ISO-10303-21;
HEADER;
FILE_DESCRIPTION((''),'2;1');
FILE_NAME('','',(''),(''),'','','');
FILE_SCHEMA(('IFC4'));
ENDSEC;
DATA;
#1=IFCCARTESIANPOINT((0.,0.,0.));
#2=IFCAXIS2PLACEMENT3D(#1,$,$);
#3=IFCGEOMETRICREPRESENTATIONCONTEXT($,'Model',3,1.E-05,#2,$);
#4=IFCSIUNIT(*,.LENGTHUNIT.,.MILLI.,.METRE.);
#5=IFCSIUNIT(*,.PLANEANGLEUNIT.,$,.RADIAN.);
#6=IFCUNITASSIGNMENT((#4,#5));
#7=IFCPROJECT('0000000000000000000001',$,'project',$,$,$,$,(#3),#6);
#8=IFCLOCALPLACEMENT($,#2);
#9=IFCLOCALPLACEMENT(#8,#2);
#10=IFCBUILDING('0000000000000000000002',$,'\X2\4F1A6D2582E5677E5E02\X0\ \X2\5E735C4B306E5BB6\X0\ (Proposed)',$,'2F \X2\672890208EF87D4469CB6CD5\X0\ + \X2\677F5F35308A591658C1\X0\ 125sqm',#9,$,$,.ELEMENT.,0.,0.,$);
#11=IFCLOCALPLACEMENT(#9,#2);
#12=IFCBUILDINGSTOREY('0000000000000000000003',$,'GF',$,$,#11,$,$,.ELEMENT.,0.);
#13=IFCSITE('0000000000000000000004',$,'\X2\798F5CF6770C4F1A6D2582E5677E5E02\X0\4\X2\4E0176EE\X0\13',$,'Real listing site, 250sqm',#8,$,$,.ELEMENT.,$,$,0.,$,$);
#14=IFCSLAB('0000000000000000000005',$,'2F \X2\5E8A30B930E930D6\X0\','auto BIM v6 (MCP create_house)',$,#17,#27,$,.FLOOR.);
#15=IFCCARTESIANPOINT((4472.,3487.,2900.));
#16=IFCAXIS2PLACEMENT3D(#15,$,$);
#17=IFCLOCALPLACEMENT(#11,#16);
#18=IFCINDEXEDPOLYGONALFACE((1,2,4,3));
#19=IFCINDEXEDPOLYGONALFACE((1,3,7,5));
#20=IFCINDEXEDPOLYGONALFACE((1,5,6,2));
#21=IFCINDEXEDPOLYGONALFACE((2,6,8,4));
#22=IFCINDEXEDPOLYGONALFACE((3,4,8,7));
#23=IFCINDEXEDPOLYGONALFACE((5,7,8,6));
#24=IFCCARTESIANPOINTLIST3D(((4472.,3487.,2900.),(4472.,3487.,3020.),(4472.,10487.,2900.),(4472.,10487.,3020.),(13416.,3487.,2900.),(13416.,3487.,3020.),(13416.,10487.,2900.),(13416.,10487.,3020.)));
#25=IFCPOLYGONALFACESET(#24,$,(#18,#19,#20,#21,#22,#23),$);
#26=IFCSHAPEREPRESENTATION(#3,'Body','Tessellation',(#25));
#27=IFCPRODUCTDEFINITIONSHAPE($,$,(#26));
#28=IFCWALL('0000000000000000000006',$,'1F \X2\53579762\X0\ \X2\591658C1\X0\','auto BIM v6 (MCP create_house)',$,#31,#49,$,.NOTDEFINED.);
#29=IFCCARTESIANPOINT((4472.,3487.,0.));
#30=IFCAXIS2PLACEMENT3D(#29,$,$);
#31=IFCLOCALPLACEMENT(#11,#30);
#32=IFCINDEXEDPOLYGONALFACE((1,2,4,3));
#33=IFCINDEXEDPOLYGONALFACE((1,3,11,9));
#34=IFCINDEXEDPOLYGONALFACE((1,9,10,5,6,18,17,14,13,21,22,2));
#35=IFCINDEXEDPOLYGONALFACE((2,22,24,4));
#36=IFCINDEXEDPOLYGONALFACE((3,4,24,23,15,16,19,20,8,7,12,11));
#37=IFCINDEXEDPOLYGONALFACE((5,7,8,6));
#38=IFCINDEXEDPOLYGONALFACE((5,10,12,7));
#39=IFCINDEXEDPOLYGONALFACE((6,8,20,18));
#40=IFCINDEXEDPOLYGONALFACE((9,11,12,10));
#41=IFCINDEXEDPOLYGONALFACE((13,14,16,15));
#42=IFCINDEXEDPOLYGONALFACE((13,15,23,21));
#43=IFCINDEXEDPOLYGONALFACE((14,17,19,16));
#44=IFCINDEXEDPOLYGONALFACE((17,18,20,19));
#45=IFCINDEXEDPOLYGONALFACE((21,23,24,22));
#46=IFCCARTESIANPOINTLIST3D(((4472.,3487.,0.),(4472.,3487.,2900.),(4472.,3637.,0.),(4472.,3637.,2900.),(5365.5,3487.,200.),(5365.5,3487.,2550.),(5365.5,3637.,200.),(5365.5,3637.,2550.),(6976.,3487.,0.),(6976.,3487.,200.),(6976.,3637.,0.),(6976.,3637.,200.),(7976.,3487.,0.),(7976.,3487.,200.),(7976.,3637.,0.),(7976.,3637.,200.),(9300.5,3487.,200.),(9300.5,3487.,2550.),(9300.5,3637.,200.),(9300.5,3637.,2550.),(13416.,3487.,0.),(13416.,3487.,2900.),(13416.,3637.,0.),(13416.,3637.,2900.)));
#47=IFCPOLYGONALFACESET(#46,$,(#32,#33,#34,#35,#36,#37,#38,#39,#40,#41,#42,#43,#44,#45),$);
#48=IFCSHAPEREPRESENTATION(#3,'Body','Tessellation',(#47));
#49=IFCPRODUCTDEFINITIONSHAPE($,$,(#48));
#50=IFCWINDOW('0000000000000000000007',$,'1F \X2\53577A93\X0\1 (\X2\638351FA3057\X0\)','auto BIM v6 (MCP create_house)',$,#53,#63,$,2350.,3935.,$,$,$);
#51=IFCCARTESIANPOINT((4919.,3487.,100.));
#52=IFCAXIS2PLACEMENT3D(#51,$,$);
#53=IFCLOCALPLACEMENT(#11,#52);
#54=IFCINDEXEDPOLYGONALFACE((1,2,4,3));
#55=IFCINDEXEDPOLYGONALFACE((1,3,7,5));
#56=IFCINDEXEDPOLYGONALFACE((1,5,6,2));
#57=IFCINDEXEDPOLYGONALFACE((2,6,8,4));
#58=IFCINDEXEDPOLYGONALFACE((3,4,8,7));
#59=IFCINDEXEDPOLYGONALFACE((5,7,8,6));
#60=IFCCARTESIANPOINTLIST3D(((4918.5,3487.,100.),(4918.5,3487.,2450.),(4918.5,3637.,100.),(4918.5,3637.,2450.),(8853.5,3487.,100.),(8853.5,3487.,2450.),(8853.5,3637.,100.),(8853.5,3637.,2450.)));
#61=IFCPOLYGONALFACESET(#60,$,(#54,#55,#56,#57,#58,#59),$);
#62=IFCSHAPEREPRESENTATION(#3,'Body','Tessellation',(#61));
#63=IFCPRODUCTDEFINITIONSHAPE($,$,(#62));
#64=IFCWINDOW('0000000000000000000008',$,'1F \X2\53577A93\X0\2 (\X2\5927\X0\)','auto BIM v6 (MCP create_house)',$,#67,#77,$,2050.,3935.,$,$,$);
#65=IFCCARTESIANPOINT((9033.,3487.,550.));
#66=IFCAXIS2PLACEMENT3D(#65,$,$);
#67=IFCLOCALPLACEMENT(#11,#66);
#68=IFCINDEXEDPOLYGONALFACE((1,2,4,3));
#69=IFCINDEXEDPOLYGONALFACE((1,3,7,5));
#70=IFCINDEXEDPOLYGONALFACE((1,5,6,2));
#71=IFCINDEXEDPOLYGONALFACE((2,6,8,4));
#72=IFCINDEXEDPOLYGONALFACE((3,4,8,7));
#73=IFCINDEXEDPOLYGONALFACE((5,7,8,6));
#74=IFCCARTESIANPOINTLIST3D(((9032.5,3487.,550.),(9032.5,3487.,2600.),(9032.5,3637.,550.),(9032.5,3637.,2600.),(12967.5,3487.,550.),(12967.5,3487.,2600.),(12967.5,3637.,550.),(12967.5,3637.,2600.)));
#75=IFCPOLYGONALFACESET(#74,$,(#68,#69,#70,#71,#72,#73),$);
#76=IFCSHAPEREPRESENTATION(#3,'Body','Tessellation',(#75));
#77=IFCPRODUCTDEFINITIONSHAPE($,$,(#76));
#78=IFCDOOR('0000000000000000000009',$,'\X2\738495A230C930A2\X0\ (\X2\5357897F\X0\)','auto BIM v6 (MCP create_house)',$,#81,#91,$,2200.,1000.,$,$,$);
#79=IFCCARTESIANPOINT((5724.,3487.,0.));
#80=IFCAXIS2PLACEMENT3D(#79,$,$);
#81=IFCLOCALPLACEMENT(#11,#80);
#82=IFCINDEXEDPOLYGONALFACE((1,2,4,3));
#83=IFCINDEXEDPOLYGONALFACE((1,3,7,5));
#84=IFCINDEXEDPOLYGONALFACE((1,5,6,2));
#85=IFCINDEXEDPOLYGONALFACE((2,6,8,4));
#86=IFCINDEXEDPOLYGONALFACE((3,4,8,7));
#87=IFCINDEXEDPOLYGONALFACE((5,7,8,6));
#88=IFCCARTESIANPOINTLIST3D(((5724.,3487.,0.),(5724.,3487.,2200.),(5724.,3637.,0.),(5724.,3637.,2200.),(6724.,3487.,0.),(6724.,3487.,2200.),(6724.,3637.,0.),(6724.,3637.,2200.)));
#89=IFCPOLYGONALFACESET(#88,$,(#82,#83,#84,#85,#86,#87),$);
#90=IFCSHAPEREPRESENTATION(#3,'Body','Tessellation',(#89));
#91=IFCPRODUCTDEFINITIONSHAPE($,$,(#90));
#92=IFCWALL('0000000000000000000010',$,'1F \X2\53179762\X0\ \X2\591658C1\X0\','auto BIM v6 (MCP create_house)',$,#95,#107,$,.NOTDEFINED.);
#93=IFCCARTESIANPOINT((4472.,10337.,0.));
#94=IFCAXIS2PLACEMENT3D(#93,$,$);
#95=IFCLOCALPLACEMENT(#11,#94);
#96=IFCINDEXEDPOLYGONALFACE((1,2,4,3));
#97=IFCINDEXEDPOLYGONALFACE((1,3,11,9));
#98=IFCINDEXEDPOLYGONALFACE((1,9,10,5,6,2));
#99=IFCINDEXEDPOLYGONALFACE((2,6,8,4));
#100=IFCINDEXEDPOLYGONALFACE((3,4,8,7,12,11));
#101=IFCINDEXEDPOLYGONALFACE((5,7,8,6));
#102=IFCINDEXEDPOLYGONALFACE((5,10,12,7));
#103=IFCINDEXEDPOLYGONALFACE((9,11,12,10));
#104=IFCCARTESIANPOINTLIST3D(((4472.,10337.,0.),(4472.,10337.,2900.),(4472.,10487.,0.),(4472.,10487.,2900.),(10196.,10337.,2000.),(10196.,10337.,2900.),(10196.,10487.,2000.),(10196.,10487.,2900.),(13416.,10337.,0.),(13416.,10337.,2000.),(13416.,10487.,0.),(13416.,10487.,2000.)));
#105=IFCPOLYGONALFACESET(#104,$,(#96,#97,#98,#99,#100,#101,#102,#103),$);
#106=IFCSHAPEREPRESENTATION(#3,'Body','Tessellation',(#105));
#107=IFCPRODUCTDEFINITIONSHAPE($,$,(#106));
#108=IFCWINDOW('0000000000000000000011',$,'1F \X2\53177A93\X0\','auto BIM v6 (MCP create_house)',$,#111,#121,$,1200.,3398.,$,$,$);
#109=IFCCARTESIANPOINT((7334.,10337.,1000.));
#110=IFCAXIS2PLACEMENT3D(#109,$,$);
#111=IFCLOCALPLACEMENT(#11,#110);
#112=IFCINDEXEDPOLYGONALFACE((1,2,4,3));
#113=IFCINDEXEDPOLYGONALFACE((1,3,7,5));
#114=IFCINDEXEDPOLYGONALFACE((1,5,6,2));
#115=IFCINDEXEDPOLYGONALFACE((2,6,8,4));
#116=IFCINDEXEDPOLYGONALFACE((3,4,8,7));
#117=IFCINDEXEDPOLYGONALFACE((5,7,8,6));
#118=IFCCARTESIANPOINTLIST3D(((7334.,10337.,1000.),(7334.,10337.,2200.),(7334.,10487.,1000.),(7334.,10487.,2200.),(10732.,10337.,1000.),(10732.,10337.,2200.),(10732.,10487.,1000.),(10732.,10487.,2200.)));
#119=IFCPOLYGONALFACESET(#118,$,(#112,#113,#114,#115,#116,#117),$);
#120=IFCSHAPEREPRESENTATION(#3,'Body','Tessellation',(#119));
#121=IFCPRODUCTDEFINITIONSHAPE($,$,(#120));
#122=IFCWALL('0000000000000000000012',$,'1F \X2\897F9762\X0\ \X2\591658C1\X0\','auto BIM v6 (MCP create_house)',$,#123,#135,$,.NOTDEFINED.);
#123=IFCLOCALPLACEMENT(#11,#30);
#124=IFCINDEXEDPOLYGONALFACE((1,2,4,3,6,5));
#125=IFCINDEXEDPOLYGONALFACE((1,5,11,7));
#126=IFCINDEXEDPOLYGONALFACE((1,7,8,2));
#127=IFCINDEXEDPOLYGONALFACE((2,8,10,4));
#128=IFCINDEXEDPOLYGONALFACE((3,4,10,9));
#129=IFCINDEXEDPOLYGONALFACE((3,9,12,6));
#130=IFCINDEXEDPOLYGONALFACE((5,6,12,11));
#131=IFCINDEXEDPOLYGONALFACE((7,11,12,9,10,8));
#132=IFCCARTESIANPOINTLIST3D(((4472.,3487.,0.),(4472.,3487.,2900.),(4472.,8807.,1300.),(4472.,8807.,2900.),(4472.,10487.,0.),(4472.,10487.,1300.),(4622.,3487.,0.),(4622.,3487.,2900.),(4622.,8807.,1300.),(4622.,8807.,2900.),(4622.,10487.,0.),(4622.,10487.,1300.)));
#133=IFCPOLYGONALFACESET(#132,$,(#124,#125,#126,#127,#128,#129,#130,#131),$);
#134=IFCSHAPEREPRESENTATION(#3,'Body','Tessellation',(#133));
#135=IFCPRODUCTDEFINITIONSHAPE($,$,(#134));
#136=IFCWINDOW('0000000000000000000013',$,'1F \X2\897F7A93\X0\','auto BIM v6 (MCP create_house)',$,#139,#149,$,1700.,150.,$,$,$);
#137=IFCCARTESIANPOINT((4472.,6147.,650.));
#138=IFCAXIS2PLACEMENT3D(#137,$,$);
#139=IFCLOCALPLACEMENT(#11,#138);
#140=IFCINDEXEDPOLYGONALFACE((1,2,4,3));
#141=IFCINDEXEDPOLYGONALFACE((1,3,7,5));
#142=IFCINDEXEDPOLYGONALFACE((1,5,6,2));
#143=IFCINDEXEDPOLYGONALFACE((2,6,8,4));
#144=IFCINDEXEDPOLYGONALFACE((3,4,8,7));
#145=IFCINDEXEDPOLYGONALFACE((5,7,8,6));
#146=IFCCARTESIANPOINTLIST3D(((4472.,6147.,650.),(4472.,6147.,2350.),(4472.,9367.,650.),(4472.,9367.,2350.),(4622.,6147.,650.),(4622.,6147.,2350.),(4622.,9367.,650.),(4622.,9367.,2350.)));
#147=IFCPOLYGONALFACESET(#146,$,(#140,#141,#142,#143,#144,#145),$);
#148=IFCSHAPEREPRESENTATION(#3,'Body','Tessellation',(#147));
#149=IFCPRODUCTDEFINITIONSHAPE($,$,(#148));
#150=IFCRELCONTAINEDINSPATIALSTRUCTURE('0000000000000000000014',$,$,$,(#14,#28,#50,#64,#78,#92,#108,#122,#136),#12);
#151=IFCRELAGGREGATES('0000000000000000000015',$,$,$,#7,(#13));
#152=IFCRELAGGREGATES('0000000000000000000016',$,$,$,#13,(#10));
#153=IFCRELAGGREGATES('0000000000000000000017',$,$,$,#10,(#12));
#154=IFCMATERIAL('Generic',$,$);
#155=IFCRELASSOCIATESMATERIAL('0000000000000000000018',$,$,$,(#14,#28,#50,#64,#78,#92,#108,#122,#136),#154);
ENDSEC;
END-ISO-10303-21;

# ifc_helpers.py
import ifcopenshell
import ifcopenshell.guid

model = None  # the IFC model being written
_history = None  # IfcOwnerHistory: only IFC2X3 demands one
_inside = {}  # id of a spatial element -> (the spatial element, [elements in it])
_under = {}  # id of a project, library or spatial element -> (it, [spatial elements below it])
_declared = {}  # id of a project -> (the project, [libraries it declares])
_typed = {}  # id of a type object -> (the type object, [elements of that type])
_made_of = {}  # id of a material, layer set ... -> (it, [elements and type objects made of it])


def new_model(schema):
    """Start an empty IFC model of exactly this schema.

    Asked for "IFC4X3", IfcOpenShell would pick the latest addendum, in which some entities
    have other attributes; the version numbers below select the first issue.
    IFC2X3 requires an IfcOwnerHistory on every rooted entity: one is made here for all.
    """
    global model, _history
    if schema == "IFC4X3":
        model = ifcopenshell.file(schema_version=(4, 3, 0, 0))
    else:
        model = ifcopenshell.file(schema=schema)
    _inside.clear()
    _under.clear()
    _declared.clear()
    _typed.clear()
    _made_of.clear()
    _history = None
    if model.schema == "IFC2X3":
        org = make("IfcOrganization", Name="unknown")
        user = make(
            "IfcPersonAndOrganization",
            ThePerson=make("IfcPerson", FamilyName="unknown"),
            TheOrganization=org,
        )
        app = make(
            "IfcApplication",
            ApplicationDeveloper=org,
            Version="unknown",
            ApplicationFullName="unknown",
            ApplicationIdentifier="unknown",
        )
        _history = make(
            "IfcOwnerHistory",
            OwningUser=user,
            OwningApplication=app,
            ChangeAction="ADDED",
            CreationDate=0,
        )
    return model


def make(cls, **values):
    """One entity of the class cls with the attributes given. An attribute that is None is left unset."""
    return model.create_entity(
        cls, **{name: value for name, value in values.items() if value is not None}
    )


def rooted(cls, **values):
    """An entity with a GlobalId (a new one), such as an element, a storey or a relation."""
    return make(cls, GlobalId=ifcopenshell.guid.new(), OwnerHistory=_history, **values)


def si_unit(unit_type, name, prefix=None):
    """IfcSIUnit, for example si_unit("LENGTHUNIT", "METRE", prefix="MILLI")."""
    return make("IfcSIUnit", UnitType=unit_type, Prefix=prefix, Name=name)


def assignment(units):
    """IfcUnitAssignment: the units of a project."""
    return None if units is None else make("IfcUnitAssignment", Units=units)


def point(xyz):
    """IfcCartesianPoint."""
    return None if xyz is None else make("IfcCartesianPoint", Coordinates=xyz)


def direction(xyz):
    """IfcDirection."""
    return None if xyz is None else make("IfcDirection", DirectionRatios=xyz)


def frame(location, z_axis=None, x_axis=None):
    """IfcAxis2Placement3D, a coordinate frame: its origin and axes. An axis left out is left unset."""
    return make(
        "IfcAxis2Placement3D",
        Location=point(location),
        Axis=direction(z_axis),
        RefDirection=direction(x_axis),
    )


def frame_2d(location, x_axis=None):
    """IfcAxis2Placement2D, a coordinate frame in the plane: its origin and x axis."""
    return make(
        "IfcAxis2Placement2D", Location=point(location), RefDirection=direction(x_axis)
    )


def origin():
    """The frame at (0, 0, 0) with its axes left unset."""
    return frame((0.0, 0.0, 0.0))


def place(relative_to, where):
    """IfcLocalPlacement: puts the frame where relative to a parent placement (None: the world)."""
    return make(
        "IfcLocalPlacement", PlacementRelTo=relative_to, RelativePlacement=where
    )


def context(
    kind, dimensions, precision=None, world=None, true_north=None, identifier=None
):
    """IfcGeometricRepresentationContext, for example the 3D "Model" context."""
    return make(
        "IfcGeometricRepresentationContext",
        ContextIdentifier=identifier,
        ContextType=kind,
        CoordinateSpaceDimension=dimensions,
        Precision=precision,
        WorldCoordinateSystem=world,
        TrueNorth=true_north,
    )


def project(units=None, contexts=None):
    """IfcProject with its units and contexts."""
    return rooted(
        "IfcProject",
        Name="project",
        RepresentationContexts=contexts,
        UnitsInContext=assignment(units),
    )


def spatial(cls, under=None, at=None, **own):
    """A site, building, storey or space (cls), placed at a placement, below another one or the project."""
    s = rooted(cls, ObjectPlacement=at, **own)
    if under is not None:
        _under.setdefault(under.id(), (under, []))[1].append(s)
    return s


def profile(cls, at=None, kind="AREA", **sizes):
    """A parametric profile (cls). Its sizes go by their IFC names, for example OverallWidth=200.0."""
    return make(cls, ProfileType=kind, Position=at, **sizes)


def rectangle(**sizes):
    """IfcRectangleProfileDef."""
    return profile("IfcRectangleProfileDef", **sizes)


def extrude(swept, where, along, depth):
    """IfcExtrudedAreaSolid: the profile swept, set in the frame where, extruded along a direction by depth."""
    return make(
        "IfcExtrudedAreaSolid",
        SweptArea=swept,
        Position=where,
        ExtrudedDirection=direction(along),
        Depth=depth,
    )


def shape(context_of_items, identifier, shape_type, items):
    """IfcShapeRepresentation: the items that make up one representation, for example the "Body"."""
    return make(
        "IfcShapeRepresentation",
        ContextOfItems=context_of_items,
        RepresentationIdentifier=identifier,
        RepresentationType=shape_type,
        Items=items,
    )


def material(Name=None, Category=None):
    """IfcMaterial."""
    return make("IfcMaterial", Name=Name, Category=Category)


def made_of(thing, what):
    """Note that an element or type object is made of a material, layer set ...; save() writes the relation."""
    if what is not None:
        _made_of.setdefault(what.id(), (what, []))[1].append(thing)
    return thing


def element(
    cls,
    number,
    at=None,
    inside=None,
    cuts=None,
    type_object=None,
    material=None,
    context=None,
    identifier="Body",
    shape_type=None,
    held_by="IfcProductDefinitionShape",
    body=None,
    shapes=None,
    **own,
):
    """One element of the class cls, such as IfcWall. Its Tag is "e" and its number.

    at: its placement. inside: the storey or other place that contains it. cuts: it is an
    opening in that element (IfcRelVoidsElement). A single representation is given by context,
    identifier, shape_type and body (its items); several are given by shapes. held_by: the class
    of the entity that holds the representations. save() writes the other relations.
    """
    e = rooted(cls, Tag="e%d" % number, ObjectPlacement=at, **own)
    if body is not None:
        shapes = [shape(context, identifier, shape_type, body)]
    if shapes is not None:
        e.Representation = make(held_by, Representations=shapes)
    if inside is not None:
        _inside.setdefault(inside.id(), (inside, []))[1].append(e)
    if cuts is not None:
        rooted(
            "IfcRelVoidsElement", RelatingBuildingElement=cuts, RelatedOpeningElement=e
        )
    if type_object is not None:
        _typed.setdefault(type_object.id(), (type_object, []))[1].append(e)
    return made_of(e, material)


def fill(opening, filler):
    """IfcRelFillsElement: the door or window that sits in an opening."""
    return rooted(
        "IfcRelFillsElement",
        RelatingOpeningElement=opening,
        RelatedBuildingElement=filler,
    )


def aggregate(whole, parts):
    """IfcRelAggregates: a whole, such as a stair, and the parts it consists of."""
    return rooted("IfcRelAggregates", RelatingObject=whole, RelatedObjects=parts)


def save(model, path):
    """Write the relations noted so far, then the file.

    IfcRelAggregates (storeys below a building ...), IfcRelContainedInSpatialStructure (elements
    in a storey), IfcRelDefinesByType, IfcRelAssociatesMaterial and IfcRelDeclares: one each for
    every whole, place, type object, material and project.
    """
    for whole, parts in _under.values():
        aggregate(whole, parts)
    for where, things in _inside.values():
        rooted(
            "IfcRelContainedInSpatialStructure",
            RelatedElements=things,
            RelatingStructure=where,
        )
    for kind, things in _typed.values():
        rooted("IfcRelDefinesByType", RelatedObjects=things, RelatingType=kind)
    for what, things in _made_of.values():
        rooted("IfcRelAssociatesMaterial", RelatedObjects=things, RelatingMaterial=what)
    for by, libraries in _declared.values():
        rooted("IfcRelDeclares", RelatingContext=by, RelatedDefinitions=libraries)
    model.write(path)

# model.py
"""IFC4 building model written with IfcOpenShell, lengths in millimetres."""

from ifc_helpers import new_model, si_unit, frame, frame_2d, origin, place, context, project, spatial, rectangle, extrude, material, element, fill, save


model = new_model("IFC4")

# Units and contexts
model_context = context("Model", 3, precision=1e-05, world=origin())
ifc_project = project(units=[si_unit("LENGTHUNIT", "METRE", prefix="MILLI"), si_unit("PLANEANGLEUNIT", "RADIAN")], contexts=[model_context])

# Site, building, storey
site_placement = place(None, origin())
site = spatial("IfcSite", under=ifc_project, at=site_placement, Name="福島県会津若松市4丁目13", ObjectType="Real listing site, 250sqm", CompositionType="ELEMENT", RefElevation=0.0)
building_placement = place(site_placement, origin())
building = spatial("IfcBuilding", under=site, at=building_placement, Name="会津若松市 平屋の家 (Proposed)", ObjectType="2F 木造軸組構法 + 板張り外壁 125sqm", CompositionType="ELEMENT", ElevationOfRefHeight=0.0, ElevationOfTerrain=0.0)
storey_placement = place(building_placement, origin())
storey = spatial("IfcBuildingStorey", under=building, at=storey_placement, Name="GF", CompositionType="ELEMENT", Elevation=0.0)

# Slab
ifc_material = material(Name="Generic")
slab_1_placement = place(storey_placement, frame((4472.0, 3487.0, 2900.0)))
element("IfcSlab", 1, at=slab_1_placement, inside=storey, material=ifc_material, Name="2F 床スラブ", Description="auto BIM v6 (MCP create_house)", PredefinedType="FLOOR", context=model_context, shape_type="SweptSolid", body=[
    extrude(rectangle(XDim=8944.0, YDim=7000.0, at=frame_2d((4472.0, 3500.0))), frame((4472.0, 3487.0, 2900.0)), (0.0, 0.0, 1.0), 120.0),
])

# Wall, openings, windows, door
wall_1_placement = place(storey_placement, frame((4472.0, 3487.0, 0.0)))
wall_1 = element("IfcWall", 2, at=wall_1_placement, inside=storey, material=ifc_material, Name="1F 南面 外壁", Description="auto BIM v6 (MCP create_house)", PredefinedType="NOTDEFINED", context=model_context, shape_type="SweptSolid", body=[
    extrude(rectangle(XDim=8944.0, YDim=150.0, at=frame_2d((4472.0, 75.0))), frame((4472.0, 3487.0, 0.0)), (0.0, 0.0, 1.0), 2900.0),
])
opening_1_placement = place(storey_placement, frame((4919.0, 3487.0, 100.0)))
opening_1 = element("IfcOpeningElement", 3, at=opening_1_placement, cuts=wall_1, PredefinedType="NOTDEFINED", context=model_context, shape_type="SweptSolid", body=[
    extrude(rectangle(XDim=3935.0, YDim=150.0, at=frame_2d((1967.0, 75.0))), frame((4919.0, 3487.0, 100.0)), (0.0, 0.0, 1.0), 2350.0),
])
opening_2_placement = place(storey_placement, frame((9033.0, 3487.0, 550.0)))
opening_2 = element("IfcOpeningElement", 4, at=opening_2_placement, cuts=wall_1, PredefinedType="NOTDEFINED", context=model_context, shape_type="SweptSolid", body=[
    extrude(rectangle(XDim=3935.0, YDim=150.0, at=frame_2d((1967.0, 75.0))), frame((9033.0, 3487.0, 550.0)), (0.0, 0.0, 1.0), 2050.0),
])
opening_3_placement = place(storey_placement, frame((5724.0, 3487.0, 0.0)))
opening_3 = element("IfcOpeningElement", 5, at=opening_3_placement, cuts=wall_1, PredefinedType="NOTDEFINED", context=model_context, shape_type="SweptSolid", body=[
    extrude(rectangle(XDim=1000.0, YDim=150.0, at=frame_2d((500.0, 75.0))), frame((5724.0, 3487.0, 0.0)), (0.0, 0.0, 1.0), 2200.0),
])
window_1_placement = place(storey_placement, frame((4919.0, 3487.0, 100.0)))
window_1 = element("IfcWindow", 6, at=window_1_placement, inside=storey, material=ifc_material, Name="1F 南窓1 (掃出し)", Description="auto BIM v6 (MCP create_house)", OverallHeight=2350.0, OverallWidth=3935.0, context=model_context, shape_type="SweptSolid", body=[
    extrude(rectangle(XDim=3935.0, YDim=150.0, at=frame_2d((1967.0, 75.0))), frame((4919.0, 3487.0, 100.0)), (0.0, 0.0, 1.0), 2350.0),
])
fill(opening_1, window_1)
window_2_placement = place(storey_placement, frame((9033.0, 3487.0, 550.0)))
window_2 = element("IfcWindow", 7, at=window_2_placement, inside=storey, material=ifc_material, Name="1F 南窓2 (大)", Description="auto BIM v6 (MCP create_house)", OverallHeight=2050.0, OverallWidth=3935.0, context=model_context, shape_type="SweptSolid", body=[
    extrude(rectangle(XDim=3935.0, YDim=150.0, at=frame_2d((1967.0, 75.0))), frame((9033.0, 3487.0, 550.0)), (0.0, 0.0, 1.0), 2050.0),
])
fill(opening_2, window_2)
door_placement = place(storey_placement, frame((5724.0, 3487.0, 0.0)))
door = element("IfcDoor", 8, at=door_placement, inside=storey, material=ifc_material, Name="玄関ドア (南西)", Description="auto BIM v6 (MCP create_house)", OverallHeight=2200.0, OverallWidth=1000.0, context=model_context, shape_type="SweptSolid", body=[
    extrude(rectangle(XDim=1000.0, YDim=150.0, at=frame_2d((500.0, 75.0))), frame((5724.0, 3487.0, 0.0)), (0.0, 0.0, 1.0), 2200.0),
])
fill(opening_3, door)

# Walls, openings, windows
wall_2_placement = place(storey_placement, frame((4472.0, 10337.0, 0.0)))
wall_2 = element("IfcWall", 9, at=wall_2_placement, inside=storey, material=ifc_material, Name="1F 北面 外壁", Description="auto BIM v6 (MCP create_house)", PredefinedType="NOTDEFINED", context=model_context, shape_type="SweptSolid", body=[
    extrude(rectangle(XDim=8944.0, YDim=150.0, at=frame_2d((4472.0, 75.0))), frame((4472.0, 10337.0, 0.0)), (0.0, 0.0, 1.0), 2900.0),
])
opening_4_placement = place(storey_placement, frame((7334.0, 10337.0, 1000.0)))
opening_4 = element("IfcOpeningElement", 10, at=opening_4_placement, cuts=wall_2, PredefinedType="NOTDEFINED", context=model_context, shape_type="SweptSolid", body=[
    extrude(rectangle(XDim=3398.0, YDim=150.0, at=frame_2d((1699.0, 75.0))), frame((7334.0, 10337.0, 1000.0)), (0.0, 0.0, 1.0), 1200.0),
])
window_3_placement = place(storey_placement, frame((7334.0, 10337.0, 1000.0)))
window_3 = element("IfcWindow", 11, at=window_3_placement, inside=storey, material=ifc_material, Name="1F 北窓", Description="auto BIM v6 (MCP create_house)", OverallHeight=1200.0, OverallWidth=3398.0, context=model_context, shape_type="SweptSolid", body=[
    extrude(rectangle(XDim=3398.0, YDim=150.0, at=frame_2d((1699.0, 75.0))), frame((7334.0, 10337.0, 1000.0)), (0.0, 0.0, 1.0), 1200.0),
])
fill(opening_4, window_3)
wall_3_placement = place(storey_placement, frame((4472.0, 3487.0, 0.0)))
wall_3 = element("IfcWall", 12, at=wall_3_placement, inside=storey, material=ifc_material, Name="1F 西面 外壁", Description="auto BIM v6 (MCP create_house)", PredefinedType="NOTDEFINED", context=model_context, shape_type="SweptSolid", body=[
    extrude(rectangle(XDim=150.0, YDim=7000.0, at=frame_2d((75.0, 3500.0))), frame((4472.0, 3487.0, 0.0)), (0.0, 0.0, 1.0), 2900.0),
])
opening_5_placement = place(storey_placement, frame((4472.0, 6147.0, 650.0)))
opening_5 = element("IfcOpeningElement", 13, at=opening_5_placement, cuts=wall_3, PredefinedType="NOTDEFINED", context=model_context, shape_type="SweptSolid", body=[
    extrude(rectangle(XDim=150.0, YDim=3220.0, at=frame_2d((75.0, 1610.0))), frame((4472.0, 6147.0, 650.0)), (0.0, 0.0, 1.0), 1700.0),
])
window_4_placement = place(storey_placement, frame((4472.0, 6147.0, 650.0)))
window_4 = element("IfcWindow", 14, at=window_4_placement, inside=storey, material=ifc_material, Name="1F 西窓", Description="auto BIM v6 (MCP create_house)", OverallHeight=1700.0, OverallWidth=150.0, context=model_context, shape_type="SweptSolid", body=[
    extrude(rectangle(XDim=150.0, YDim=3220.0, at=frame_2d((75.0, 1610.0))), frame((4472.0, 6147.0, 650.0)), (0.0, 0.0, 1.0), 1700.0),
])
fill(opening_5, window_4)

save(model, "model.ifc")
